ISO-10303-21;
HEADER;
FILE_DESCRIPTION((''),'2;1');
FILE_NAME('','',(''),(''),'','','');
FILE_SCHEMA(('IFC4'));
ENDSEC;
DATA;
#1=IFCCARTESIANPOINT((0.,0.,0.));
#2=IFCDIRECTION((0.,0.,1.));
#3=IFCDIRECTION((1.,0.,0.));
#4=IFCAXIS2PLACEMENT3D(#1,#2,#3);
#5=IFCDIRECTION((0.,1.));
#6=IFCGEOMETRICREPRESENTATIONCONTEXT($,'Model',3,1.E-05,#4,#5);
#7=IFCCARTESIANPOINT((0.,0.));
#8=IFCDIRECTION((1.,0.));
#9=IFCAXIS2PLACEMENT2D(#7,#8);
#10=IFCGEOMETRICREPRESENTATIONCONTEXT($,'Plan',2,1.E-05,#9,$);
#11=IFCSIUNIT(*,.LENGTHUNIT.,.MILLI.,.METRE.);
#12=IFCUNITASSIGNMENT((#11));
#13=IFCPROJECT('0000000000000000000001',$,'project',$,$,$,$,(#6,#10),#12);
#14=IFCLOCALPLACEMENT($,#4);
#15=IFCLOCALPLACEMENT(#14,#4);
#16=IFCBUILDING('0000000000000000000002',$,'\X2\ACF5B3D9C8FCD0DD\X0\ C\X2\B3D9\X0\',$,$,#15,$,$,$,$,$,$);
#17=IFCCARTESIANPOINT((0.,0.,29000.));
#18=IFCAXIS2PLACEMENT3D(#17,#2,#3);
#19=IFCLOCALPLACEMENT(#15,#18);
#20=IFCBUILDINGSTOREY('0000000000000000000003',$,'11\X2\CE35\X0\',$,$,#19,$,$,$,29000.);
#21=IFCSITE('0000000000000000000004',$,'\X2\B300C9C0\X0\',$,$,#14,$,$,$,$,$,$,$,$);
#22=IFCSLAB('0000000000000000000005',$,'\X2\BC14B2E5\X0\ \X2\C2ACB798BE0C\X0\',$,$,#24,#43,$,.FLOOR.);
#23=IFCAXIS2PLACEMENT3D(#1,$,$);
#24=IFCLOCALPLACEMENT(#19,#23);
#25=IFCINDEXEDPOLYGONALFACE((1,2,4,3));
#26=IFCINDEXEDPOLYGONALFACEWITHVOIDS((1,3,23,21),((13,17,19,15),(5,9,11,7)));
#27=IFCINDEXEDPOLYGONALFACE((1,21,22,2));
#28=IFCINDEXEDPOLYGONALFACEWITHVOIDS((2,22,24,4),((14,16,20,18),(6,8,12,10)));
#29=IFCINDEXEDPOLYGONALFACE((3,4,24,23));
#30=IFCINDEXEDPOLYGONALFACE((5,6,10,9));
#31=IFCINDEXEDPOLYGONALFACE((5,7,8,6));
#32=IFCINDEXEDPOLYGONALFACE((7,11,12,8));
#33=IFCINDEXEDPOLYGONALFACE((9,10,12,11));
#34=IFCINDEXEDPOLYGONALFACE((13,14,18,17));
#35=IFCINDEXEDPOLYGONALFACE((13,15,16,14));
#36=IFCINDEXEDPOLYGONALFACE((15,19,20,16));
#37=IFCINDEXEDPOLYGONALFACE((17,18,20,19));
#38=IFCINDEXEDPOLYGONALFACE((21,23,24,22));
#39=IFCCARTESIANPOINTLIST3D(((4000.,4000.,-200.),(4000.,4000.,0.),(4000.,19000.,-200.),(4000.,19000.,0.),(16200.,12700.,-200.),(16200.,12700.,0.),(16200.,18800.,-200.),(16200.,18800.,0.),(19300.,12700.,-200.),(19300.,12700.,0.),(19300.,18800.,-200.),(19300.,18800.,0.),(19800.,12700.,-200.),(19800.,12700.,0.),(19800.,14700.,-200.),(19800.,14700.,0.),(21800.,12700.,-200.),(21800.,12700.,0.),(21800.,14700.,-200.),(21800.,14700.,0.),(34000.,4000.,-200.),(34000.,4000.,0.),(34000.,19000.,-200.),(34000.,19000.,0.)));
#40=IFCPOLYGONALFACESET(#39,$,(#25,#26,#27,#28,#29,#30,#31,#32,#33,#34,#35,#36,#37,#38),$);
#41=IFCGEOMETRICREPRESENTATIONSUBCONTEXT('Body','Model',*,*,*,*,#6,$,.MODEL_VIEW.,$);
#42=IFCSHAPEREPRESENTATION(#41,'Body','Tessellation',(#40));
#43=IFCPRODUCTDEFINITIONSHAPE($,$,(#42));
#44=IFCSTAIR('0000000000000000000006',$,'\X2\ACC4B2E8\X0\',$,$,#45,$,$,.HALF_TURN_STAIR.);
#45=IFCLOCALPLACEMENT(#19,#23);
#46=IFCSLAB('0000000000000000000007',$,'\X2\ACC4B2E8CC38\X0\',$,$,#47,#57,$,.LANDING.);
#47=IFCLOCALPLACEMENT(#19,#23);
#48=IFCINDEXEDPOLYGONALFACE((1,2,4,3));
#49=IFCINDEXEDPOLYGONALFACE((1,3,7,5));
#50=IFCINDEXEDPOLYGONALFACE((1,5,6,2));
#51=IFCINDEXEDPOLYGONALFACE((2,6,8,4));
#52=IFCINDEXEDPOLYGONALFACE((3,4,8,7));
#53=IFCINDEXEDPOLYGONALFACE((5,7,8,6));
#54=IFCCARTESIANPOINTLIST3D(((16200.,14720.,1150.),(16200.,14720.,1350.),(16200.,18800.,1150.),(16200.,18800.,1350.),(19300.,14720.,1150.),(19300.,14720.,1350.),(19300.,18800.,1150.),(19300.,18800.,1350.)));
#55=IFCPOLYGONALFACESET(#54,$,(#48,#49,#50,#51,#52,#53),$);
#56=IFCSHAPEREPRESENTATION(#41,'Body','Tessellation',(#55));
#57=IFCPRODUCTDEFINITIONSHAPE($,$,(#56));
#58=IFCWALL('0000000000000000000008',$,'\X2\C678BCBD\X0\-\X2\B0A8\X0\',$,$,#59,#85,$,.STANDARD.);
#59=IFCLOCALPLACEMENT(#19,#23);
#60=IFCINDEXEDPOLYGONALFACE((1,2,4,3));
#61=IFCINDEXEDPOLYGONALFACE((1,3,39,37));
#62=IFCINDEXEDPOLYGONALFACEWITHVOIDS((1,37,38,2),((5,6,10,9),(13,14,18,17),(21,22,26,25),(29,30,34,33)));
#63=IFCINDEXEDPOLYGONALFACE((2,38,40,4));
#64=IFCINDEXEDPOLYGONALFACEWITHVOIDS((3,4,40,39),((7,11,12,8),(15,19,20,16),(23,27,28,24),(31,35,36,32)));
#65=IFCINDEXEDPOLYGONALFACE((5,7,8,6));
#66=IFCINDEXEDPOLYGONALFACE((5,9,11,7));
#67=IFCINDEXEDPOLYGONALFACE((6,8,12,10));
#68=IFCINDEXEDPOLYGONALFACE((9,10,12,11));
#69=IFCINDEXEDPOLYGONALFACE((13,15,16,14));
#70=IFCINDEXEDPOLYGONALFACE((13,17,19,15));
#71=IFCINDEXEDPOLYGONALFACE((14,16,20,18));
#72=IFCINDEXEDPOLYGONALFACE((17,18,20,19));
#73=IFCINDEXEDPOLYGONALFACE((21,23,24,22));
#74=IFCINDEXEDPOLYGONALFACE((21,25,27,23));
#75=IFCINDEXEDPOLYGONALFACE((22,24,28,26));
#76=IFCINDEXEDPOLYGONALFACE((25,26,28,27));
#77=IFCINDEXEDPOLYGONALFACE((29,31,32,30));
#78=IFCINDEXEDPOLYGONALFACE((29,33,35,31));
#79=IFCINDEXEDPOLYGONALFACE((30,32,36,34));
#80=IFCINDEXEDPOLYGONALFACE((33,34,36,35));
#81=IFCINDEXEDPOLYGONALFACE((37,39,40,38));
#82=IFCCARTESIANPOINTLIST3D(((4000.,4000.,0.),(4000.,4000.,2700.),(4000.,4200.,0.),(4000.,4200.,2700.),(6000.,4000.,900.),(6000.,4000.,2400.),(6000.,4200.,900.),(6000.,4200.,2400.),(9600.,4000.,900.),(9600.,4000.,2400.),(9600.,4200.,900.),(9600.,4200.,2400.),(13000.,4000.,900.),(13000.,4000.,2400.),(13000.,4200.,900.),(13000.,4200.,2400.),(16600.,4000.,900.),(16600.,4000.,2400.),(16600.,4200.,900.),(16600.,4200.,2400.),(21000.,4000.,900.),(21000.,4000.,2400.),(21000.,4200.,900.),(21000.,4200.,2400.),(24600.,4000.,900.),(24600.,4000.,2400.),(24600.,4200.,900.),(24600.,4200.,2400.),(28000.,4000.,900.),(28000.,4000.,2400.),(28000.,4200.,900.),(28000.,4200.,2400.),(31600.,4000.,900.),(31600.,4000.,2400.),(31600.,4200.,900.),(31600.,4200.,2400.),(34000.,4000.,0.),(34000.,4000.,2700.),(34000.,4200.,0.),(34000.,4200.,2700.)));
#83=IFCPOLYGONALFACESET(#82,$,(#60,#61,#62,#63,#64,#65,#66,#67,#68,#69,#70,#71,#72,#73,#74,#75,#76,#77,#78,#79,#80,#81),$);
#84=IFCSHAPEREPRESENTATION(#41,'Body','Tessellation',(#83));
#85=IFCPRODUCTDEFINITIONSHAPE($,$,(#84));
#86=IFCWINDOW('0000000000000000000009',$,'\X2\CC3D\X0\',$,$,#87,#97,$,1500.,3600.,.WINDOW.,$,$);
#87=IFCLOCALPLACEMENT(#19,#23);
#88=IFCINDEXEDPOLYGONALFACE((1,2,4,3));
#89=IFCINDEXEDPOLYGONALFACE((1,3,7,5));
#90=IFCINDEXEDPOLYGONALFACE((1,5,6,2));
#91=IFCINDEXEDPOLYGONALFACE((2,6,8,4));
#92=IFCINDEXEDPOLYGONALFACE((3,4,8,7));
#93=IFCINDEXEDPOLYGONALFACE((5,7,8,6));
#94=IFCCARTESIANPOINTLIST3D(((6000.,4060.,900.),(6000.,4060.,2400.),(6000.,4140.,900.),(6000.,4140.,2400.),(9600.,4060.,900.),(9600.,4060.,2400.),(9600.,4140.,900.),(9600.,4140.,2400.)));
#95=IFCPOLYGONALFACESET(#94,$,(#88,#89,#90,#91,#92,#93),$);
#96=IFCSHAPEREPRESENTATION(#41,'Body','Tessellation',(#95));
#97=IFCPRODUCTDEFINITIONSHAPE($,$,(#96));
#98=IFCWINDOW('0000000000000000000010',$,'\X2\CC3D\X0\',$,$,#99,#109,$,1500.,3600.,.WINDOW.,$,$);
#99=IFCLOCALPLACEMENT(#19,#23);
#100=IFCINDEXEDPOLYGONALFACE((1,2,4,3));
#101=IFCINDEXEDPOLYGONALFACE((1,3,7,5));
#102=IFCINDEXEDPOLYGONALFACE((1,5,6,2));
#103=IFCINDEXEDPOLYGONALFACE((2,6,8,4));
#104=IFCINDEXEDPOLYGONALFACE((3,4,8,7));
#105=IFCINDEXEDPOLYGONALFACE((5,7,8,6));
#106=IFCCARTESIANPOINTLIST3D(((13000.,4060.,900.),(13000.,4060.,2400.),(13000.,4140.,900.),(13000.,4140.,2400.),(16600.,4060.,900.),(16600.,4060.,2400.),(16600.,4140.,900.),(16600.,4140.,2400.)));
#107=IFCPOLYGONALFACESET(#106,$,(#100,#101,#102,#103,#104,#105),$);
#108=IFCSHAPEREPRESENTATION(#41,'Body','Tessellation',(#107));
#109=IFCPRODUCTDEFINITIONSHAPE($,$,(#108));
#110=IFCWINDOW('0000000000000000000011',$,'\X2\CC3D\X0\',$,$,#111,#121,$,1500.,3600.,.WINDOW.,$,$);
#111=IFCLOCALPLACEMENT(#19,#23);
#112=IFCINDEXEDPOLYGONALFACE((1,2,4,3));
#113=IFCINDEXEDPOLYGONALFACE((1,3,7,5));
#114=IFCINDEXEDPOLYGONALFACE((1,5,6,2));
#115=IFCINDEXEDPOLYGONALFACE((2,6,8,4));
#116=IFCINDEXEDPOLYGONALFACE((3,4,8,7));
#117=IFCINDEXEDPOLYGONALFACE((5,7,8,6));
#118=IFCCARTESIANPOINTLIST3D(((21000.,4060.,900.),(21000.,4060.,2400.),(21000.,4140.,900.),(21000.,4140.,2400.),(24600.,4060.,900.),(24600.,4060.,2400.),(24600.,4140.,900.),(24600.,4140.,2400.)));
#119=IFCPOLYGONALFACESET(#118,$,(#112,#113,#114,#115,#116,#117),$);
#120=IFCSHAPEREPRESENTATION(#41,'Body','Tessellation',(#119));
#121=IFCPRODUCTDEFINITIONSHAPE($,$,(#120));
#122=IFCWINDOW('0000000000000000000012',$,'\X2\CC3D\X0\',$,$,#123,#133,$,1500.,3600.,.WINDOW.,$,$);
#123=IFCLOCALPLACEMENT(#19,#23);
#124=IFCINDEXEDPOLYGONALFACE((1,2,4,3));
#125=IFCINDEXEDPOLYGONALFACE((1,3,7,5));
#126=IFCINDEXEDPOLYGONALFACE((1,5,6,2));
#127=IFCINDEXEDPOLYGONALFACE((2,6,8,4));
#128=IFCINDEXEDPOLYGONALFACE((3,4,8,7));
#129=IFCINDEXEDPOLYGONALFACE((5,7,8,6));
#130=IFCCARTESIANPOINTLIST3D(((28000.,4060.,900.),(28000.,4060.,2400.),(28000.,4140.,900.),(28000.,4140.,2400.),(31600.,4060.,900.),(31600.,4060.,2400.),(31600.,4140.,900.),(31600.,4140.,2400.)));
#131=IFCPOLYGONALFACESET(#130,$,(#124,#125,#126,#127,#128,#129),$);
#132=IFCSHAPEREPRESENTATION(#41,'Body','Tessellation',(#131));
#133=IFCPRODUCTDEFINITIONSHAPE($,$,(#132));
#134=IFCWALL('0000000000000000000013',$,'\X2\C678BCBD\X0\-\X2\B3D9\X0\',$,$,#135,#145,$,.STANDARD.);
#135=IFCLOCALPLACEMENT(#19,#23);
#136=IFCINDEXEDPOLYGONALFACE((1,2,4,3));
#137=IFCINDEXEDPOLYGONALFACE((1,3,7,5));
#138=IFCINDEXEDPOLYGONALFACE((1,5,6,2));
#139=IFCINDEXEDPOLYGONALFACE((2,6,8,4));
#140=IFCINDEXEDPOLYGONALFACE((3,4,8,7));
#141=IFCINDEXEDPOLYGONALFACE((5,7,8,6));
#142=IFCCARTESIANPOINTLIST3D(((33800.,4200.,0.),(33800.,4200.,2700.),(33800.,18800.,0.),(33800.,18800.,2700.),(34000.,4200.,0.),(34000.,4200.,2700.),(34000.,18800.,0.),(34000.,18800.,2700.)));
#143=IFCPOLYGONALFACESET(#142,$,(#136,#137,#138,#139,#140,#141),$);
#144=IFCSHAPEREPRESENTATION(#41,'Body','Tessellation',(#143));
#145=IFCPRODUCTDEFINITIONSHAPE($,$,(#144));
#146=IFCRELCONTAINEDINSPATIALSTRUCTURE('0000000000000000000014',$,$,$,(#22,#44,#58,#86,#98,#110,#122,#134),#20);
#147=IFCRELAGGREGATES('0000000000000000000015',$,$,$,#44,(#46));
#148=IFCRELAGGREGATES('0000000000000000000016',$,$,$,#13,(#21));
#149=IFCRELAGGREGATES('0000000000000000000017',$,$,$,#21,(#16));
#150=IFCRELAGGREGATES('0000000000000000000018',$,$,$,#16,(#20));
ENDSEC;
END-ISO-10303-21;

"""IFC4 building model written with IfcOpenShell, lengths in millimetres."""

from ifc_helpers import new_model, si_unit, direction, frame, origin_with_axes, origin_2d_with_axis, place, context, subcontext, project, spatial, polyline, outline, extrude, element, fill, aggregate, save


model = new_model("IFC4")

# Units and contexts
model_context = context("Model", 3, precision=1e-05, world=origin_with_axes(), true_north=direction((0.0, 1.0)))
plan_context = context("Plan", 2, precision=1e-05, world=origin_2d_with_axis())
body_context = subcontext(model_context, "Body", "Model", "MODEL_VIEW")
ifc_project = project(units=[si_unit("LENGTHUNIT", "METRE", prefix="MILLI")], contexts=[model_context, plan_context])

# Site, building, storey
site_placement = place(None, origin_with_axes())
site = spatial("IfcSite", under=ifc_project, at=site_placement, Name="대지")
building_placement = place(site_placement, origin_with_axes())
building = spatial("IfcBuilding", under=site, at=building_placement, Name="공동주택 C동")
storey_placement = place(building_placement, frame((0.0, 0.0, 29000.0), z_axis=(0.0, 0.0, 1.0), x_axis=(1.0, 0.0, 0.0)))
storey = spatial("IfcBuildingStorey", under=building, at=storey_placement, Name="11층", Elevation=29000.0)

# Slab
slab_1_placement = place(storey_placement, origin_with_axes())
element("IfcSlab", 1, at=slab_1_placement, inside=storey, Name="바닥 슬래브", PredefinedType="FLOOR", context=body_context, shape_type="SweptSolid", body=[
    extrude(outline(polyline([(4000.0, 4000.0), (34000.0, 4000.0), (34000.0, 19000.0), (4000.0, 19000.0), (4000.0, 4000.0)]), holes=[polyline([(16200.0, 12700.0), (19300.0, 12700.0), (19300.0, 18800.0), (16200.0, 18800.0), (16200.0, 12700.0)]), polyline([(19800.0, 12700.0), (21800.0, 12700.0), (21800.0, 14700.0), (19800.0, 14700.0), (19800.0, 12700.0)])]), frame((0.0, 0.0, -200.0), z_axis=(0.0, 0.0, 1.0), x_axis=(1.0, 0.0, 0.0)), (0.0, 0.0, 1.0), 200.0),
])

# Stair, slab
stair_placement = place(storey_placement, origin_with_axes())
stair = element("IfcStair", 2, at=stair_placement, inside=storey, Name="계단", PredefinedType="HALF_TURN_STAIR")
slab_2_placement = place(stair_placement, origin_with_axes())
slab_2 = element("IfcSlab", 3, at=slab_2_placement, Name="계단참", PredefinedType="LANDING", context=body_context, shape_type="SweptSolid", body=[
    extrude(outline(polyline([(16200.0, 14720.0), (19300.0, 14720.0), (19300.0, 18800.0), (16200.0, 18800.0), (16200.0, 14720.0)])), frame((0.0, 0.0, 1150.0), z_axis=(0.0, 0.0, 1.0), x_axis=(1.0, 0.0, 0.0)), (0.0, 0.0, 1.0), 200.0),
])

# Wall, openings, windows
wall_1_placement = place(storey_placement, origin_with_axes())
wall_1 = element("IfcWall", 4, at=wall_1_placement, inside=storey, Name="외벽-남", PredefinedType="STANDARD", context=body_context, shape_type="SweptSolid", body=[
    extrude(outline(polyline([(4000.0, 4200.0), (34000.0, 4200.0), (34000.0, 4000.0), (4000.0, 4000.0), (4000.0, 4200.0)])), origin_with_axes(), (0.0, 0.0, 1.0), 2700.0),
])
opening_1_placement = place(storey_placement, origin_with_axes())
opening_1 = element("IfcOpeningElement", 5, at=opening_1_placement, cuts=wall_1, PredefinedType="OPENING", context=body_context, shape_type="SweptSolid", body=[
    extrude(outline(polyline([(6000.0, 3950.0), (9600.0, 3950.0), (9600.0, 4250.0), (6000.0, 4250.0), (6000.0, 3950.0)])), frame((0.0, 0.0, 900.0), z_axis=(0.0, 0.0, 1.0), x_axis=(1.0, 0.0, 0.0)), (0.0, 0.0, 1.0), 1500.0),
])
opening_2_placement = place(storey_placement, origin_with_axes())
opening_2 = element("IfcOpeningElement", 6, at=opening_2_placement, cuts=wall_1, PredefinedType="OPENING", context=body_context, shape_type="SweptSolid", body=[
    extrude(outline(polyline([(13000.0, 3950.0), (16600.0, 3950.0), (16600.0, 4250.0), (13000.0, 4250.0), (13000.0, 3950.0)])), frame((0.0, 0.0, 900.0), z_axis=(0.0, 0.0, 1.0), x_axis=(1.0, 0.0, 0.0)), (0.0, 0.0, 1.0), 1500.0),
])
opening_3_placement = place(storey_placement, origin_with_axes())
opening_3 = element("IfcOpeningElement", 7, at=opening_3_placement, cuts=wall_1, PredefinedType="OPENING", context=body_context, shape_type="SweptSolid", body=[
    extrude(outline(polyline([(21000.0, 3950.0), (24600.0, 3950.0), (24600.0, 4250.0), (21000.0, 4250.0), (21000.0, 3950.0)])), frame((0.0, 0.0, 900.0), z_axis=(0.0, 0.0, 1.0), x_axis=(1.0, 0.0, 0.0)), (0.0, 0.0, 1.0), 1500.0),
])
opening_4_placement = place(storey_placement, origin_with_axes())
opening_4 = element("IfcOpeningElement", 8, at=opening_4_placement, cuts=wall_1, PredefinedType="OPENING", context=body_context, shape_type="SweptSolid", body=[
    extrude(outline(polyline([(28000.0, 3950.0), (31600.0, 3950.0), (31600.0, 4250.0), (28000.0, 4250.0), (28000.0, 3950.0)])), frame((0.0, 0.0, 900.0), z_axis=(0.0, 0.0, 1.0), x_axis=(1.0, 0.0, 0.0)), (0.0, 0.0, 1.0), 1500.0),
])
window_1_placement = place(storey_placement, origin_with_axes())
window_1 = element("IfcWindow", 9, at=window_1_placement, inside=storey, Name="창", OverallHeight=1500.0, OverallWidth=3600.0, PredefinedType="WINDOW", context=body_context, shape_type="SweptSolid", body=[
    extrude(outline(polyline([(6000.0, 4060.0), (9600.0, 4060.0), (9600.0, 4140.0), (6000.0, 4140.0), (6000.0, 4060.0)])), frame((0.0, 0.0, 900.0), z_axis=(0.0, 0.0, 1.0), x_axis=(1.0, 0.0, 0.0)), (0.0, 0.0, 1.0), 1500.0),
])
fill(opening_1, window_1)
window_2_placement = place(storey_placement, origin_with_axes())
window_2 = element("IfcWindow", 10, at=window_2_placement, inside=storey, Name="창", OverallHeight=1500.0, OverallWidth=3600.0, PredefinedType="WINDOW", context=body_context, shape_type="SweptSolid", body=[
    extrude(outline(polyline([(13000.0, 4060.0), (16600.0, 4060.0), (16600.0, 4140.0), (13000.0, 4140.0), (13000.0, 4060.0)])), frame((0.0, 0.0, 900.0), z_axis=(0.0, 0.0, 1.0), x_axis=(1.0, 0.0, 0.0)), (0.0, 0.0, 1.0), 1500.0),
])
fill(opening_2, window_2)
window_3_placement = place(storey_placement, origin_with_axes())
window_3 = element("IfcWindow", 11, at=window_3_placement, inside=storey, Name="창", OverallHeight=1500.0, OverallWidth=3600.0, PredefinedType="WINDOW", context=body_context, shape_type="SweptSolid", body=[
    extrude(outline(polyline([(21000.0, 4060.0), (24600.0, 4060.0), (24600.0, 4140.0), (21000.0, 4140.0), (21000.0, 4060.0)])), frame((0.0, 0.0, 900.0), z_axis=(0.0, 0.0, 1.0), x_axis=(1.0, 0.0, 0.0)), (0.0, 0.0, 1.0), 1500.0),
])
fill(opening_3, window_3)
window_4_placement = place(storey_placement, origin_with_axes())
window_4 = element("IfcWindow", 12, at=window_4_placement, inside=storey, Name="창", OverallHeight=1500.0, OverallWidth=3600.0, PredefinedType="WINDOW", context=body_context, shape_type="SweptSolid", body=[
    extrude(outline(polyline([(28000.0, 4060.0), (31600.0, 4060.0), (31600.0, 4140.0), (28000.0, 4140.0), (28000.0, 4060.0)])), frame((0.0, 0.0, 900.0), z_axis=(0.0, 0.0, 1.0), x_axis=(1.0, 0.0, 0.0)), (0.0, 0.0, 1.0), 1500.0),
])
fill(opening_4, window_4)

# Wall
wall_2_placement = place(storey_placement, origin_with_axes())
element("IfcWall", 13, at=wall_2_placement, inside=storey, Name="외벽-동", PredefinedType="STANDARD", context=body_context, shape_type="SweptSolid", body=[
    extrude(outline(polyline([(33800.0, 4200.0), (33800.0, 18800.0), (34000.0, 18800.0), (34000.0, 4200.0), (33800.0, 4200.0)])), origin_with_axes(), (0.0, 0.0, 1.0), 2700.0),
])

aggregate(stair, [slab_2])

save(model, "model.ifc")
